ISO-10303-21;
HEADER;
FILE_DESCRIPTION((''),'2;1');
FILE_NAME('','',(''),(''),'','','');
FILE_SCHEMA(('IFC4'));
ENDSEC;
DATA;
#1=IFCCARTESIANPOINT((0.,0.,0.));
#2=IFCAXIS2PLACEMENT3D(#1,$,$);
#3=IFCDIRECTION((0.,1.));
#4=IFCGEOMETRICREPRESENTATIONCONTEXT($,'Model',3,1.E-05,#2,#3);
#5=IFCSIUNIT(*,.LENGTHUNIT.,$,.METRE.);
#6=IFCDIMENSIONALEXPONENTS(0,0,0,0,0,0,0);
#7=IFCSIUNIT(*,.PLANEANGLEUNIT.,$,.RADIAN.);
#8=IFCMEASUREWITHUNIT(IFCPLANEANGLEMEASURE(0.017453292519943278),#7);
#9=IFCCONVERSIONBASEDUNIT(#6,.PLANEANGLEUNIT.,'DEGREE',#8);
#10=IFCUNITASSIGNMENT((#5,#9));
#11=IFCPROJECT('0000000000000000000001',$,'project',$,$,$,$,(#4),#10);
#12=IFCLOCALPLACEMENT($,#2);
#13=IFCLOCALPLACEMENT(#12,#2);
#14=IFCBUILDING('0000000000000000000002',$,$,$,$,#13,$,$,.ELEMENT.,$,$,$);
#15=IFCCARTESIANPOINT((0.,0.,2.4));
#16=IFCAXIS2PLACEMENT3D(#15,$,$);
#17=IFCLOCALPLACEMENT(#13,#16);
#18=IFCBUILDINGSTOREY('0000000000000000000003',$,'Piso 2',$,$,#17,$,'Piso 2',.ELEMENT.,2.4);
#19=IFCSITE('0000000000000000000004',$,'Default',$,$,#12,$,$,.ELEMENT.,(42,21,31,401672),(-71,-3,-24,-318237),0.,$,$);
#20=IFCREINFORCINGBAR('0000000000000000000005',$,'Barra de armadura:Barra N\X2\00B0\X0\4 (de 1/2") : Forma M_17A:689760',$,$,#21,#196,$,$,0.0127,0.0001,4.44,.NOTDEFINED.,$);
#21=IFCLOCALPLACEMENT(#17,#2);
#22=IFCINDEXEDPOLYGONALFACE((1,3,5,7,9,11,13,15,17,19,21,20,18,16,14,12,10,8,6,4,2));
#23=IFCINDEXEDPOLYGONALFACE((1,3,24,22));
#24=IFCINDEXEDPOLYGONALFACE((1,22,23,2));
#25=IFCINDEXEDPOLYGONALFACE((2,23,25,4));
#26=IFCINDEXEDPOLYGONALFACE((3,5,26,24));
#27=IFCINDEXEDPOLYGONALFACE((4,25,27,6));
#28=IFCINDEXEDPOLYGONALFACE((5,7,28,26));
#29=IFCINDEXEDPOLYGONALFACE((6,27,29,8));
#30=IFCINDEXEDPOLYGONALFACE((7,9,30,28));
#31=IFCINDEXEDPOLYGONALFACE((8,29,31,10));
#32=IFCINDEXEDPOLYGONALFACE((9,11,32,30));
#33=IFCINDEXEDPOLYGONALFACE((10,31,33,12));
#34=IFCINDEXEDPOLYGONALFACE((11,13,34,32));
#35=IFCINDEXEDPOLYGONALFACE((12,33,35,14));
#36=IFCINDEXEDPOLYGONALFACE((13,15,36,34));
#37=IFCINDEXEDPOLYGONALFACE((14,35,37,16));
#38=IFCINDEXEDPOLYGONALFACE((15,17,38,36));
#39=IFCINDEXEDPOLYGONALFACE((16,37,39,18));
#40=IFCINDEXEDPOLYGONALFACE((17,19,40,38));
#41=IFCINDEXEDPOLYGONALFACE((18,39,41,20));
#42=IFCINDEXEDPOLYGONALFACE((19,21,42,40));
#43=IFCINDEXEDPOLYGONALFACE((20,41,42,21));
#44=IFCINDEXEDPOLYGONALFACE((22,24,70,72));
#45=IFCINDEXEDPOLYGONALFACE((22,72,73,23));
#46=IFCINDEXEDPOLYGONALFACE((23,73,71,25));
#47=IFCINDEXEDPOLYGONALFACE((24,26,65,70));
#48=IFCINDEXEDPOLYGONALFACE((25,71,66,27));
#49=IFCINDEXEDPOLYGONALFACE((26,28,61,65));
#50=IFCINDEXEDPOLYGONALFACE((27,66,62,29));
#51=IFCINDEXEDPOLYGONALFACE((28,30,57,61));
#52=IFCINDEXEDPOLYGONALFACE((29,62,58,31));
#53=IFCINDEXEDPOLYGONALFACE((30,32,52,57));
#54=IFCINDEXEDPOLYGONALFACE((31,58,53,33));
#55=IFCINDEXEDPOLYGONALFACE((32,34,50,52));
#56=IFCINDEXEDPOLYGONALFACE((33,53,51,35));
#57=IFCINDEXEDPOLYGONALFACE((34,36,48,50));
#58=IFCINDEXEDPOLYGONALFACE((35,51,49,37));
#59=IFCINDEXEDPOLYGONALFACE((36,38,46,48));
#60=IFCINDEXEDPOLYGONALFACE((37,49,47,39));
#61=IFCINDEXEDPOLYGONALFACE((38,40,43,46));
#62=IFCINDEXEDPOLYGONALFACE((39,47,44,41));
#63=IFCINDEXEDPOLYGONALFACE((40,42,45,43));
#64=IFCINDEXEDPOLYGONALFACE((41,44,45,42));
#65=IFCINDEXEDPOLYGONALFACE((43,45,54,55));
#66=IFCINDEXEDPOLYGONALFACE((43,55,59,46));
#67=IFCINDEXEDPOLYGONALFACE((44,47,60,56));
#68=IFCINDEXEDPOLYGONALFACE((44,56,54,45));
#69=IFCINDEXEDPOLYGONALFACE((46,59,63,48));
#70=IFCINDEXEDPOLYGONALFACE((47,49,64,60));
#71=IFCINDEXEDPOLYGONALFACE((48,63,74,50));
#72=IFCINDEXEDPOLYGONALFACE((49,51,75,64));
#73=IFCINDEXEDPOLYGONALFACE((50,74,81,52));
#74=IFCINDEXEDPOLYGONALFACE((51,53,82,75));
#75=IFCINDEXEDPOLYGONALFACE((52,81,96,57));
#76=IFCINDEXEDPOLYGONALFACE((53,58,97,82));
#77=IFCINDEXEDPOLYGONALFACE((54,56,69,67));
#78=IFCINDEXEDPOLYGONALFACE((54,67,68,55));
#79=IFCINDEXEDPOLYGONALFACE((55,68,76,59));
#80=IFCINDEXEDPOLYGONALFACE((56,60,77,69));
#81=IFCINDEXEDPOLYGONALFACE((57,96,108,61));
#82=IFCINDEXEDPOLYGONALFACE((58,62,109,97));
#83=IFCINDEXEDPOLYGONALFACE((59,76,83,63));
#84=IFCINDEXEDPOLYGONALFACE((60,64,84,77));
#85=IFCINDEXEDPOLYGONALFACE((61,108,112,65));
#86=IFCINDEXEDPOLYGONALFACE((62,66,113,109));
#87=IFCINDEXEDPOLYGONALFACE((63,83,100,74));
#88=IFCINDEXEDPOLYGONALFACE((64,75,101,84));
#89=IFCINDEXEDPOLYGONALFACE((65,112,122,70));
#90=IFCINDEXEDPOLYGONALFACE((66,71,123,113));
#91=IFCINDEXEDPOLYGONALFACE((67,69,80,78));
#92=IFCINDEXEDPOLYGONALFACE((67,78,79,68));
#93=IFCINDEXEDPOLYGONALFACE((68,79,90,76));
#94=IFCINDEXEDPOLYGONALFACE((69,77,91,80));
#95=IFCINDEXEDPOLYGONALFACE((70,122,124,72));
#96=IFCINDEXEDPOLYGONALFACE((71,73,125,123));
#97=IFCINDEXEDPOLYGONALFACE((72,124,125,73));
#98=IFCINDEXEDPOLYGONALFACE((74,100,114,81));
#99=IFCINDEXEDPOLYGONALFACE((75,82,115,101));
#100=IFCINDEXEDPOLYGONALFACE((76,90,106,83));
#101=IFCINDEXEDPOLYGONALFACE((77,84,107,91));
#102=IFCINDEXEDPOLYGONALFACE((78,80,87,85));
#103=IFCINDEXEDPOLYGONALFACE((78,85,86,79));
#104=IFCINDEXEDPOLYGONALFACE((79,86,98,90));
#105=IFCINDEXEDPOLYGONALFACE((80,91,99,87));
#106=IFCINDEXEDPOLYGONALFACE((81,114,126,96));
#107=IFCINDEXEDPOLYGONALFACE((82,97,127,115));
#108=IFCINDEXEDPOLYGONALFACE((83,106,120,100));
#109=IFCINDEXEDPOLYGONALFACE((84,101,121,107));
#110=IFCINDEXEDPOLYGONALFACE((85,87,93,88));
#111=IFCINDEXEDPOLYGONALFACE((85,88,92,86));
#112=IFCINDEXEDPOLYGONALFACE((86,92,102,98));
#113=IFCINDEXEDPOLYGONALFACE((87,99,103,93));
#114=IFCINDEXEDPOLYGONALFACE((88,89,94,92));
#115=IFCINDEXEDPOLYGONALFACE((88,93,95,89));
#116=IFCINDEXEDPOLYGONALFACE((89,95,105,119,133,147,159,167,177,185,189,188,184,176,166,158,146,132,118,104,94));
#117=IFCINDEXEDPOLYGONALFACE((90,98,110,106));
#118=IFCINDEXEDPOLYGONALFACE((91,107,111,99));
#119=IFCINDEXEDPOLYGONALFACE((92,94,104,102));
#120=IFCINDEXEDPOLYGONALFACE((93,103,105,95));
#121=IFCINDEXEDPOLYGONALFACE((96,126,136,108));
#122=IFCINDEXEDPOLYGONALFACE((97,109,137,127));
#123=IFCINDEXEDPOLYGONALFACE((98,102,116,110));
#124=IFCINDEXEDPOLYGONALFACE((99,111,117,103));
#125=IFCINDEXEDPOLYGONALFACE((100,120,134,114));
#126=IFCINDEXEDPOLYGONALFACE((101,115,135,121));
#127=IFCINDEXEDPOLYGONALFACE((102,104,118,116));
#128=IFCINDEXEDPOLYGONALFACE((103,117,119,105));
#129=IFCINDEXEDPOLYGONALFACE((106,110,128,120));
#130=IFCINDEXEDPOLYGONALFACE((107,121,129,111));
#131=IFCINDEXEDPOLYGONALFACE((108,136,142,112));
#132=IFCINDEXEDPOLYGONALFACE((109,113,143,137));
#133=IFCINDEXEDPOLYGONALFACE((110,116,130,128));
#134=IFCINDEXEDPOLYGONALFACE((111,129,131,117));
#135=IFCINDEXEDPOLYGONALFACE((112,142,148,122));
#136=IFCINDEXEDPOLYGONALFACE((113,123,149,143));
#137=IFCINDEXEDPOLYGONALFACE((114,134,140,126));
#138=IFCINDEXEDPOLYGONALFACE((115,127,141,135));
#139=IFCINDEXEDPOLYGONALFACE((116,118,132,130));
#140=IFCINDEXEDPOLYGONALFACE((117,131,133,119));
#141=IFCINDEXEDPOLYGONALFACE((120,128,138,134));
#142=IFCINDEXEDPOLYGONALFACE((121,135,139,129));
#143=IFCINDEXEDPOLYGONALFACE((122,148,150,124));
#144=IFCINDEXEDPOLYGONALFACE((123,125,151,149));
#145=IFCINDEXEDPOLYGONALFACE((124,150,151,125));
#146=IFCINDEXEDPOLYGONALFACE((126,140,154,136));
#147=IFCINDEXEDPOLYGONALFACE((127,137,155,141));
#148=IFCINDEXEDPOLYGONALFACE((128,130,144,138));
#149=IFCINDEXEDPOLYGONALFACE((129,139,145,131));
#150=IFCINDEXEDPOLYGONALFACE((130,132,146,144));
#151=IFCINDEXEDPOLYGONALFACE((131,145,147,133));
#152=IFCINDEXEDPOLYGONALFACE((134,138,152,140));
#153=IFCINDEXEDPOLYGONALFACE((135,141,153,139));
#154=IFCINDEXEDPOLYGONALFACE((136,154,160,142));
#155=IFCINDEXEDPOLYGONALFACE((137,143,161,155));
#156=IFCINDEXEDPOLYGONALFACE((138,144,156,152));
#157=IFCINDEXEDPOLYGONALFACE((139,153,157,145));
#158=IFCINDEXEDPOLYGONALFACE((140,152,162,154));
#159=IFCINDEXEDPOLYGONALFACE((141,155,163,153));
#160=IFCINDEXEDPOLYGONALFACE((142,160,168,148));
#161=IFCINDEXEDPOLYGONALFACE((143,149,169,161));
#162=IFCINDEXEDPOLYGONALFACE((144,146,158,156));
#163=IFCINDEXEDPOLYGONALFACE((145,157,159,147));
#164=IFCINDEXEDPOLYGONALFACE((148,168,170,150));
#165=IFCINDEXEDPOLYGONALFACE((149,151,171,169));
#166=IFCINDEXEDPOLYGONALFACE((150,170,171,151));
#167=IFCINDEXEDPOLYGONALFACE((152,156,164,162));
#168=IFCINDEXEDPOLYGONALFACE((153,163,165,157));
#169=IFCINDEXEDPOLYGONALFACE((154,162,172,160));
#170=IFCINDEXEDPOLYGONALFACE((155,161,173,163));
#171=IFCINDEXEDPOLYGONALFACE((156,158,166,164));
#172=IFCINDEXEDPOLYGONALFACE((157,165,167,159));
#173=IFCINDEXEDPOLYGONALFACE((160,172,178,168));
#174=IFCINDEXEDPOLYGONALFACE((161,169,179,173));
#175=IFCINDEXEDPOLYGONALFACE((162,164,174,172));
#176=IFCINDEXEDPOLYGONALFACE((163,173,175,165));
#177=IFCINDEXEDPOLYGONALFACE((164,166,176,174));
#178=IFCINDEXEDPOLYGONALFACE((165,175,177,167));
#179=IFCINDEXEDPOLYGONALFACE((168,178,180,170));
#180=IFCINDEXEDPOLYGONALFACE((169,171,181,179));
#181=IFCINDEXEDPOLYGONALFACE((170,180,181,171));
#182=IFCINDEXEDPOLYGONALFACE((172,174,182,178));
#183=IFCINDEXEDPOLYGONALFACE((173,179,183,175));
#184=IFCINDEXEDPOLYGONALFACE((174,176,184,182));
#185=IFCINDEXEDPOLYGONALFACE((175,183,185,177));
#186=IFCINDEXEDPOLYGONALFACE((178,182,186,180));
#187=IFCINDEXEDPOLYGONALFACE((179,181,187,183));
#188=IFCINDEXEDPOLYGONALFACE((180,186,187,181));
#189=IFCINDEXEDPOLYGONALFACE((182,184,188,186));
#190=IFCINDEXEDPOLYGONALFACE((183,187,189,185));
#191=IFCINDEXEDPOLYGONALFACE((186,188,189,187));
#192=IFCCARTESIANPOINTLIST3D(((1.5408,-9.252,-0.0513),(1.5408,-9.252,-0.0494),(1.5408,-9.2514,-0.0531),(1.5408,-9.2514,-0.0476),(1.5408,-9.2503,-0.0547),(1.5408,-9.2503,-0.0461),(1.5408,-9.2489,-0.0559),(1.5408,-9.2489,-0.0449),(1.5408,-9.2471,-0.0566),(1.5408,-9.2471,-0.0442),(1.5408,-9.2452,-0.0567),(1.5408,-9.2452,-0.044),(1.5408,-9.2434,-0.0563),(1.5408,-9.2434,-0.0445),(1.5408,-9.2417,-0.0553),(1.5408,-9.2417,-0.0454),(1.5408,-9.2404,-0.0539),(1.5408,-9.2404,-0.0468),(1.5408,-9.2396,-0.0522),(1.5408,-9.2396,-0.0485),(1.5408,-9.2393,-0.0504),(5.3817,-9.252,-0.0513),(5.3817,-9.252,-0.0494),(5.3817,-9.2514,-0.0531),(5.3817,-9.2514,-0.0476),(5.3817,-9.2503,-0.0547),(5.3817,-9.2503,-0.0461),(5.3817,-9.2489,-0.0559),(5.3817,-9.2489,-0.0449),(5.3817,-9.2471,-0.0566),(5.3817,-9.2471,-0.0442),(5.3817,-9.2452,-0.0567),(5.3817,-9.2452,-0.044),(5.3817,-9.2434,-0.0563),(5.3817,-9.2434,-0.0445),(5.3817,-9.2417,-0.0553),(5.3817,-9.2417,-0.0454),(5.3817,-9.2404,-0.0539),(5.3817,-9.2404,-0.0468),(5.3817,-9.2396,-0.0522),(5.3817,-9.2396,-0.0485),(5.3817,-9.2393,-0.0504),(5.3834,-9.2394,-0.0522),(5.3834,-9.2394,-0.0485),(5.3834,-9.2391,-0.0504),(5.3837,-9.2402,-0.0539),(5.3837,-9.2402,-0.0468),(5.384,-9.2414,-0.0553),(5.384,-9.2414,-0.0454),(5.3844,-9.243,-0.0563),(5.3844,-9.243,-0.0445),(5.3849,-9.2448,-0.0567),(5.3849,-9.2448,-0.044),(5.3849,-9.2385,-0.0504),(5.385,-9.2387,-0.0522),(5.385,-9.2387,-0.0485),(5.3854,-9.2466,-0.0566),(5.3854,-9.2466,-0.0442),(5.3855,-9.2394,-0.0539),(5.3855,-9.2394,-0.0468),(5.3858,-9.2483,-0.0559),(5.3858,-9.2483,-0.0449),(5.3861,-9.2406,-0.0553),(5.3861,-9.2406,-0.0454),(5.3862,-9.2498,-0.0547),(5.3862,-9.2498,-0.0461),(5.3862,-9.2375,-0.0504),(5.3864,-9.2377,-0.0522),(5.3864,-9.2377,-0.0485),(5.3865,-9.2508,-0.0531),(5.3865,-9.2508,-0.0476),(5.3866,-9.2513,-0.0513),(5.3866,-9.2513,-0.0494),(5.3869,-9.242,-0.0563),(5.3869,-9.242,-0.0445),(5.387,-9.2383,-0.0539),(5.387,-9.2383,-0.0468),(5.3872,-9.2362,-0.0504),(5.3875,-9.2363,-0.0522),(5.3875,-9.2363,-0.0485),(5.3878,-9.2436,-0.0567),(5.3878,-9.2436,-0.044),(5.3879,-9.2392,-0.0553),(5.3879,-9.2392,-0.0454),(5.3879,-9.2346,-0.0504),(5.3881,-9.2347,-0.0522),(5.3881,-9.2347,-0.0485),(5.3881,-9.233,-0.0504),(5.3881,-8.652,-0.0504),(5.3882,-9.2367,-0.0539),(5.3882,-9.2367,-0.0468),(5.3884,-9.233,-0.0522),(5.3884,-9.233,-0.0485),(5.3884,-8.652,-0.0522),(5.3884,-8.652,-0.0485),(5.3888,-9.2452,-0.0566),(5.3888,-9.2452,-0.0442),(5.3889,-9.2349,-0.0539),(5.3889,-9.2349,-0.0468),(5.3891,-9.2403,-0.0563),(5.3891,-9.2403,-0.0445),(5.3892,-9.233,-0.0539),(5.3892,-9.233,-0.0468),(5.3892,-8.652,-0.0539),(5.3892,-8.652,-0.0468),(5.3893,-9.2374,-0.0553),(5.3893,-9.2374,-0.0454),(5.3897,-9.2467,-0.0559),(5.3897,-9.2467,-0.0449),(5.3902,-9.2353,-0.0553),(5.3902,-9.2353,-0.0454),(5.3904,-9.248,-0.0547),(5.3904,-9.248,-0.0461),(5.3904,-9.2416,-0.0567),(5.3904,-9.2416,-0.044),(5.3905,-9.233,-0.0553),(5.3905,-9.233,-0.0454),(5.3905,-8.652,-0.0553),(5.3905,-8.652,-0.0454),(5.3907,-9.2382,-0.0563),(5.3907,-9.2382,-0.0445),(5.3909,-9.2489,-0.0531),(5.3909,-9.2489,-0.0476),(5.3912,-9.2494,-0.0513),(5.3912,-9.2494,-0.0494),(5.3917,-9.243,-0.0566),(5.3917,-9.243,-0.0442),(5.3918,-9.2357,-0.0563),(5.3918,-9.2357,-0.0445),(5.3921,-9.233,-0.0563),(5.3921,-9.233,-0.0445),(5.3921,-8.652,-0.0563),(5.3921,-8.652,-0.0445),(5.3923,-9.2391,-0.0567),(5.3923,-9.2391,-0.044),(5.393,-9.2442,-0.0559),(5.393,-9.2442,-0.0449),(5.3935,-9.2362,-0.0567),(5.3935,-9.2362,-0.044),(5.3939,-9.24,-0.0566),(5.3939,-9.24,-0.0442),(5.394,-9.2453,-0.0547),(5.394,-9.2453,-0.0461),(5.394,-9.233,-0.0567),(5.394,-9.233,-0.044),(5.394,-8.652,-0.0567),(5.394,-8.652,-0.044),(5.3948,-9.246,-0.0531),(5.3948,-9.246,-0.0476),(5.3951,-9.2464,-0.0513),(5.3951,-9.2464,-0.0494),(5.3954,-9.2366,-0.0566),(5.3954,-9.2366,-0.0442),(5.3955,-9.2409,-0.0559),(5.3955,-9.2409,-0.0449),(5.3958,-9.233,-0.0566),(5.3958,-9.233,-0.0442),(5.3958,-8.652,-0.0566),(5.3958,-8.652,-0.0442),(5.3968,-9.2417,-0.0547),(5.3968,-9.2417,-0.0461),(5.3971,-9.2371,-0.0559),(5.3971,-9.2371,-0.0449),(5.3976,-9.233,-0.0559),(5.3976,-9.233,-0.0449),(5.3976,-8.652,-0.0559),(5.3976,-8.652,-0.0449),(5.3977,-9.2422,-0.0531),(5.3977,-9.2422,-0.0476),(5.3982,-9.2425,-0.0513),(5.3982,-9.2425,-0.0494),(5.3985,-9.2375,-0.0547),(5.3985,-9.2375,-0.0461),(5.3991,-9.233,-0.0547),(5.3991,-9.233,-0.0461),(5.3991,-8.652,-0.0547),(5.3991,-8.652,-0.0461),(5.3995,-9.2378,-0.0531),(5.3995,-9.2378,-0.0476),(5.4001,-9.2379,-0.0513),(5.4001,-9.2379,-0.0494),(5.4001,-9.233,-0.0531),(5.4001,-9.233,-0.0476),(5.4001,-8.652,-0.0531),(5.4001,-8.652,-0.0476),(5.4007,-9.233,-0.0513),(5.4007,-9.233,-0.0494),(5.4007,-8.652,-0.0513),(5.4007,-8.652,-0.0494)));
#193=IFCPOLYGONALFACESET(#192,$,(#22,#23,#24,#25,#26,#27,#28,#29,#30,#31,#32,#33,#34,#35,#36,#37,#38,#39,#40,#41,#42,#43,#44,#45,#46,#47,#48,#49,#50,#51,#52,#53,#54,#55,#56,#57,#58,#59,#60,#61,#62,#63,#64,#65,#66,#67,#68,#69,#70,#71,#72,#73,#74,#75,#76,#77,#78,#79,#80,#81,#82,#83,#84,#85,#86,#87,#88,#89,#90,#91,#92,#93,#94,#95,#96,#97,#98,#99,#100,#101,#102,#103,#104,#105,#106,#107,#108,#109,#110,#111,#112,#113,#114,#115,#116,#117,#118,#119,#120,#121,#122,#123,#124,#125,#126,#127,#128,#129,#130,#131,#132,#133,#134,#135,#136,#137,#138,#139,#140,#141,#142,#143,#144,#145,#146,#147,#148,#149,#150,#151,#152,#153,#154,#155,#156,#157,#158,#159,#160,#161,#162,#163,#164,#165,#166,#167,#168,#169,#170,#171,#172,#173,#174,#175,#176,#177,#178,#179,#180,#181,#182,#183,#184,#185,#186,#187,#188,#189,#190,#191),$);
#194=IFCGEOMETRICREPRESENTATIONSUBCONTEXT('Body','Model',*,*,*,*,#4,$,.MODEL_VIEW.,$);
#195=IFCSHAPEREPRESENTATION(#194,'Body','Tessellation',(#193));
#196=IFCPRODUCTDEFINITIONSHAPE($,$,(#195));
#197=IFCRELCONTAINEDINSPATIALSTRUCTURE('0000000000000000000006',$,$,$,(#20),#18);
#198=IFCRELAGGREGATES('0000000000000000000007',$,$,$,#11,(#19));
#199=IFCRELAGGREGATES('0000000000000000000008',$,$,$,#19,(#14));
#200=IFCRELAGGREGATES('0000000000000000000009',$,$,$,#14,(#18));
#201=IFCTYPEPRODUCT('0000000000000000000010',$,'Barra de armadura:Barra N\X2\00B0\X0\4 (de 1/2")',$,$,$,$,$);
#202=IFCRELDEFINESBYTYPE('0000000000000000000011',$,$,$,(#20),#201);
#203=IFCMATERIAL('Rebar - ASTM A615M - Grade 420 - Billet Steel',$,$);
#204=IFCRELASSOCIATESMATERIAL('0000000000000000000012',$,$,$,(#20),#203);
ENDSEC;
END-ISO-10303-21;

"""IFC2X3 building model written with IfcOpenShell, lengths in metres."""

from ifc_helpers import new_model, entity, si_unit, converted_unit, direction, frame, origin, place, context, subcontext, project, spatial, material, type_object, element, save


model = new_model("IFC2X3")

# Units and contexts
model_context = context("Model", 3, precision=1e-05, world=origin(), true_north=direction((0.0, 1.0)))
body_context = subcontext(model_context, "Body", "Model", "MODEL_VIEW")
ifc_project = project(units=[si_unit("LENGTHUNIT", "METRE"), converted_unit("PLANEANGLEUNIT", "DEGREE", entity("IfcPlaneAngleMeasure", 0.017453292519943278), si_unit("PLANEANGLEUNIT", "RADIAN"), dimensions=[0, 0, 0, 0, 0, 0, 0])], contexts=[model_context])

# Site, building, storey
site_placement = place(None, origin())
site = spatial("IfcSite", under=ifc_project, at=site_placement, Name="Default", CompositionType="ELEMENT", RefLatitude=(42, 21, 31, 401672), RefLongitude=(-71, -3, -24, -318237), RefElevation=0.0)
building_placement = place(site_placement, origin())
building = spatial("IfcBuilding", under=site, at=building_placement, CompositionType="ELEMENT")
storey_placement = place(building_placement, frame((0.0, 0.0, 2.4)))
storey = spatial("IfcBuildingStorey", under=building, at=storey_placement, Name="Piso 2", LongName="Piso 2", CompositionType="ELEMENT", Elevation=2.4)

# Reinforcing bar
ifc_material_1 = material(Name="Rebar - ASTM A615M - Grade 420 - Billet Steel")
type_product_1 = type_object("IfcTypeProduct", Name="Barra de armadura:Barra N°4 (de 1/2\")")
reinforcing_bar_1_placement = place(storey_placement, origin())
element("IfcReinforcingBar", 1, at=reinforcing_bar_1_placement, inside=storey, type_object=type_product_1, material=ifc_material_1, Name="Barra de armadura:Barra N°4 (de 1/2\") : Forma M_17A:689760", BarLength=4.44, BarRole="NOTDEFINED", CrossSectionArea=0.0001, NominalDiameter=0.0127, context=body_context, shape_type="AdvancedSweptSolid", body=[
    entity("IfcSweptDiskSolid", entity("IfcCompositeCurve", [entity("IfcCompositeCurveSegment", "CONTINUOUS", True, entity("IfcPolyline", [entity("IfcCartesianPoint", [1.5408, -9.2457, -0.0504]), entity("IfcCartesianPoint", [5.3817, -9.2457, -0.0504])])), entity("IfcCompositeCurveSegment", "CONTINUOUS", True, entity("IfcTrimmedCurve", entity("IfcCircle", entity("IfcAxis2Placement3D", entity("IfcCartesianPoint", [5.3817, -9.233, -0.0504])), 0.0127), [entity("IfcParameterValue", 270.0)], [entity("IfcParameterValue", 360.0)], True, "PARAMETER")), entity("IfcCompositeCurveSegment", "CONTINUOUS", True, entity("IfcPolyline", [entity("IfcCartesianPoint", [5.3944, -9.233, -0.0504]), entity("IfcCartesianPoint", [5.3944, -8.652, -0.0504])]))], False), 0.0063, None, 0.0, 92.0),
])

save(model, "model.ifc")
